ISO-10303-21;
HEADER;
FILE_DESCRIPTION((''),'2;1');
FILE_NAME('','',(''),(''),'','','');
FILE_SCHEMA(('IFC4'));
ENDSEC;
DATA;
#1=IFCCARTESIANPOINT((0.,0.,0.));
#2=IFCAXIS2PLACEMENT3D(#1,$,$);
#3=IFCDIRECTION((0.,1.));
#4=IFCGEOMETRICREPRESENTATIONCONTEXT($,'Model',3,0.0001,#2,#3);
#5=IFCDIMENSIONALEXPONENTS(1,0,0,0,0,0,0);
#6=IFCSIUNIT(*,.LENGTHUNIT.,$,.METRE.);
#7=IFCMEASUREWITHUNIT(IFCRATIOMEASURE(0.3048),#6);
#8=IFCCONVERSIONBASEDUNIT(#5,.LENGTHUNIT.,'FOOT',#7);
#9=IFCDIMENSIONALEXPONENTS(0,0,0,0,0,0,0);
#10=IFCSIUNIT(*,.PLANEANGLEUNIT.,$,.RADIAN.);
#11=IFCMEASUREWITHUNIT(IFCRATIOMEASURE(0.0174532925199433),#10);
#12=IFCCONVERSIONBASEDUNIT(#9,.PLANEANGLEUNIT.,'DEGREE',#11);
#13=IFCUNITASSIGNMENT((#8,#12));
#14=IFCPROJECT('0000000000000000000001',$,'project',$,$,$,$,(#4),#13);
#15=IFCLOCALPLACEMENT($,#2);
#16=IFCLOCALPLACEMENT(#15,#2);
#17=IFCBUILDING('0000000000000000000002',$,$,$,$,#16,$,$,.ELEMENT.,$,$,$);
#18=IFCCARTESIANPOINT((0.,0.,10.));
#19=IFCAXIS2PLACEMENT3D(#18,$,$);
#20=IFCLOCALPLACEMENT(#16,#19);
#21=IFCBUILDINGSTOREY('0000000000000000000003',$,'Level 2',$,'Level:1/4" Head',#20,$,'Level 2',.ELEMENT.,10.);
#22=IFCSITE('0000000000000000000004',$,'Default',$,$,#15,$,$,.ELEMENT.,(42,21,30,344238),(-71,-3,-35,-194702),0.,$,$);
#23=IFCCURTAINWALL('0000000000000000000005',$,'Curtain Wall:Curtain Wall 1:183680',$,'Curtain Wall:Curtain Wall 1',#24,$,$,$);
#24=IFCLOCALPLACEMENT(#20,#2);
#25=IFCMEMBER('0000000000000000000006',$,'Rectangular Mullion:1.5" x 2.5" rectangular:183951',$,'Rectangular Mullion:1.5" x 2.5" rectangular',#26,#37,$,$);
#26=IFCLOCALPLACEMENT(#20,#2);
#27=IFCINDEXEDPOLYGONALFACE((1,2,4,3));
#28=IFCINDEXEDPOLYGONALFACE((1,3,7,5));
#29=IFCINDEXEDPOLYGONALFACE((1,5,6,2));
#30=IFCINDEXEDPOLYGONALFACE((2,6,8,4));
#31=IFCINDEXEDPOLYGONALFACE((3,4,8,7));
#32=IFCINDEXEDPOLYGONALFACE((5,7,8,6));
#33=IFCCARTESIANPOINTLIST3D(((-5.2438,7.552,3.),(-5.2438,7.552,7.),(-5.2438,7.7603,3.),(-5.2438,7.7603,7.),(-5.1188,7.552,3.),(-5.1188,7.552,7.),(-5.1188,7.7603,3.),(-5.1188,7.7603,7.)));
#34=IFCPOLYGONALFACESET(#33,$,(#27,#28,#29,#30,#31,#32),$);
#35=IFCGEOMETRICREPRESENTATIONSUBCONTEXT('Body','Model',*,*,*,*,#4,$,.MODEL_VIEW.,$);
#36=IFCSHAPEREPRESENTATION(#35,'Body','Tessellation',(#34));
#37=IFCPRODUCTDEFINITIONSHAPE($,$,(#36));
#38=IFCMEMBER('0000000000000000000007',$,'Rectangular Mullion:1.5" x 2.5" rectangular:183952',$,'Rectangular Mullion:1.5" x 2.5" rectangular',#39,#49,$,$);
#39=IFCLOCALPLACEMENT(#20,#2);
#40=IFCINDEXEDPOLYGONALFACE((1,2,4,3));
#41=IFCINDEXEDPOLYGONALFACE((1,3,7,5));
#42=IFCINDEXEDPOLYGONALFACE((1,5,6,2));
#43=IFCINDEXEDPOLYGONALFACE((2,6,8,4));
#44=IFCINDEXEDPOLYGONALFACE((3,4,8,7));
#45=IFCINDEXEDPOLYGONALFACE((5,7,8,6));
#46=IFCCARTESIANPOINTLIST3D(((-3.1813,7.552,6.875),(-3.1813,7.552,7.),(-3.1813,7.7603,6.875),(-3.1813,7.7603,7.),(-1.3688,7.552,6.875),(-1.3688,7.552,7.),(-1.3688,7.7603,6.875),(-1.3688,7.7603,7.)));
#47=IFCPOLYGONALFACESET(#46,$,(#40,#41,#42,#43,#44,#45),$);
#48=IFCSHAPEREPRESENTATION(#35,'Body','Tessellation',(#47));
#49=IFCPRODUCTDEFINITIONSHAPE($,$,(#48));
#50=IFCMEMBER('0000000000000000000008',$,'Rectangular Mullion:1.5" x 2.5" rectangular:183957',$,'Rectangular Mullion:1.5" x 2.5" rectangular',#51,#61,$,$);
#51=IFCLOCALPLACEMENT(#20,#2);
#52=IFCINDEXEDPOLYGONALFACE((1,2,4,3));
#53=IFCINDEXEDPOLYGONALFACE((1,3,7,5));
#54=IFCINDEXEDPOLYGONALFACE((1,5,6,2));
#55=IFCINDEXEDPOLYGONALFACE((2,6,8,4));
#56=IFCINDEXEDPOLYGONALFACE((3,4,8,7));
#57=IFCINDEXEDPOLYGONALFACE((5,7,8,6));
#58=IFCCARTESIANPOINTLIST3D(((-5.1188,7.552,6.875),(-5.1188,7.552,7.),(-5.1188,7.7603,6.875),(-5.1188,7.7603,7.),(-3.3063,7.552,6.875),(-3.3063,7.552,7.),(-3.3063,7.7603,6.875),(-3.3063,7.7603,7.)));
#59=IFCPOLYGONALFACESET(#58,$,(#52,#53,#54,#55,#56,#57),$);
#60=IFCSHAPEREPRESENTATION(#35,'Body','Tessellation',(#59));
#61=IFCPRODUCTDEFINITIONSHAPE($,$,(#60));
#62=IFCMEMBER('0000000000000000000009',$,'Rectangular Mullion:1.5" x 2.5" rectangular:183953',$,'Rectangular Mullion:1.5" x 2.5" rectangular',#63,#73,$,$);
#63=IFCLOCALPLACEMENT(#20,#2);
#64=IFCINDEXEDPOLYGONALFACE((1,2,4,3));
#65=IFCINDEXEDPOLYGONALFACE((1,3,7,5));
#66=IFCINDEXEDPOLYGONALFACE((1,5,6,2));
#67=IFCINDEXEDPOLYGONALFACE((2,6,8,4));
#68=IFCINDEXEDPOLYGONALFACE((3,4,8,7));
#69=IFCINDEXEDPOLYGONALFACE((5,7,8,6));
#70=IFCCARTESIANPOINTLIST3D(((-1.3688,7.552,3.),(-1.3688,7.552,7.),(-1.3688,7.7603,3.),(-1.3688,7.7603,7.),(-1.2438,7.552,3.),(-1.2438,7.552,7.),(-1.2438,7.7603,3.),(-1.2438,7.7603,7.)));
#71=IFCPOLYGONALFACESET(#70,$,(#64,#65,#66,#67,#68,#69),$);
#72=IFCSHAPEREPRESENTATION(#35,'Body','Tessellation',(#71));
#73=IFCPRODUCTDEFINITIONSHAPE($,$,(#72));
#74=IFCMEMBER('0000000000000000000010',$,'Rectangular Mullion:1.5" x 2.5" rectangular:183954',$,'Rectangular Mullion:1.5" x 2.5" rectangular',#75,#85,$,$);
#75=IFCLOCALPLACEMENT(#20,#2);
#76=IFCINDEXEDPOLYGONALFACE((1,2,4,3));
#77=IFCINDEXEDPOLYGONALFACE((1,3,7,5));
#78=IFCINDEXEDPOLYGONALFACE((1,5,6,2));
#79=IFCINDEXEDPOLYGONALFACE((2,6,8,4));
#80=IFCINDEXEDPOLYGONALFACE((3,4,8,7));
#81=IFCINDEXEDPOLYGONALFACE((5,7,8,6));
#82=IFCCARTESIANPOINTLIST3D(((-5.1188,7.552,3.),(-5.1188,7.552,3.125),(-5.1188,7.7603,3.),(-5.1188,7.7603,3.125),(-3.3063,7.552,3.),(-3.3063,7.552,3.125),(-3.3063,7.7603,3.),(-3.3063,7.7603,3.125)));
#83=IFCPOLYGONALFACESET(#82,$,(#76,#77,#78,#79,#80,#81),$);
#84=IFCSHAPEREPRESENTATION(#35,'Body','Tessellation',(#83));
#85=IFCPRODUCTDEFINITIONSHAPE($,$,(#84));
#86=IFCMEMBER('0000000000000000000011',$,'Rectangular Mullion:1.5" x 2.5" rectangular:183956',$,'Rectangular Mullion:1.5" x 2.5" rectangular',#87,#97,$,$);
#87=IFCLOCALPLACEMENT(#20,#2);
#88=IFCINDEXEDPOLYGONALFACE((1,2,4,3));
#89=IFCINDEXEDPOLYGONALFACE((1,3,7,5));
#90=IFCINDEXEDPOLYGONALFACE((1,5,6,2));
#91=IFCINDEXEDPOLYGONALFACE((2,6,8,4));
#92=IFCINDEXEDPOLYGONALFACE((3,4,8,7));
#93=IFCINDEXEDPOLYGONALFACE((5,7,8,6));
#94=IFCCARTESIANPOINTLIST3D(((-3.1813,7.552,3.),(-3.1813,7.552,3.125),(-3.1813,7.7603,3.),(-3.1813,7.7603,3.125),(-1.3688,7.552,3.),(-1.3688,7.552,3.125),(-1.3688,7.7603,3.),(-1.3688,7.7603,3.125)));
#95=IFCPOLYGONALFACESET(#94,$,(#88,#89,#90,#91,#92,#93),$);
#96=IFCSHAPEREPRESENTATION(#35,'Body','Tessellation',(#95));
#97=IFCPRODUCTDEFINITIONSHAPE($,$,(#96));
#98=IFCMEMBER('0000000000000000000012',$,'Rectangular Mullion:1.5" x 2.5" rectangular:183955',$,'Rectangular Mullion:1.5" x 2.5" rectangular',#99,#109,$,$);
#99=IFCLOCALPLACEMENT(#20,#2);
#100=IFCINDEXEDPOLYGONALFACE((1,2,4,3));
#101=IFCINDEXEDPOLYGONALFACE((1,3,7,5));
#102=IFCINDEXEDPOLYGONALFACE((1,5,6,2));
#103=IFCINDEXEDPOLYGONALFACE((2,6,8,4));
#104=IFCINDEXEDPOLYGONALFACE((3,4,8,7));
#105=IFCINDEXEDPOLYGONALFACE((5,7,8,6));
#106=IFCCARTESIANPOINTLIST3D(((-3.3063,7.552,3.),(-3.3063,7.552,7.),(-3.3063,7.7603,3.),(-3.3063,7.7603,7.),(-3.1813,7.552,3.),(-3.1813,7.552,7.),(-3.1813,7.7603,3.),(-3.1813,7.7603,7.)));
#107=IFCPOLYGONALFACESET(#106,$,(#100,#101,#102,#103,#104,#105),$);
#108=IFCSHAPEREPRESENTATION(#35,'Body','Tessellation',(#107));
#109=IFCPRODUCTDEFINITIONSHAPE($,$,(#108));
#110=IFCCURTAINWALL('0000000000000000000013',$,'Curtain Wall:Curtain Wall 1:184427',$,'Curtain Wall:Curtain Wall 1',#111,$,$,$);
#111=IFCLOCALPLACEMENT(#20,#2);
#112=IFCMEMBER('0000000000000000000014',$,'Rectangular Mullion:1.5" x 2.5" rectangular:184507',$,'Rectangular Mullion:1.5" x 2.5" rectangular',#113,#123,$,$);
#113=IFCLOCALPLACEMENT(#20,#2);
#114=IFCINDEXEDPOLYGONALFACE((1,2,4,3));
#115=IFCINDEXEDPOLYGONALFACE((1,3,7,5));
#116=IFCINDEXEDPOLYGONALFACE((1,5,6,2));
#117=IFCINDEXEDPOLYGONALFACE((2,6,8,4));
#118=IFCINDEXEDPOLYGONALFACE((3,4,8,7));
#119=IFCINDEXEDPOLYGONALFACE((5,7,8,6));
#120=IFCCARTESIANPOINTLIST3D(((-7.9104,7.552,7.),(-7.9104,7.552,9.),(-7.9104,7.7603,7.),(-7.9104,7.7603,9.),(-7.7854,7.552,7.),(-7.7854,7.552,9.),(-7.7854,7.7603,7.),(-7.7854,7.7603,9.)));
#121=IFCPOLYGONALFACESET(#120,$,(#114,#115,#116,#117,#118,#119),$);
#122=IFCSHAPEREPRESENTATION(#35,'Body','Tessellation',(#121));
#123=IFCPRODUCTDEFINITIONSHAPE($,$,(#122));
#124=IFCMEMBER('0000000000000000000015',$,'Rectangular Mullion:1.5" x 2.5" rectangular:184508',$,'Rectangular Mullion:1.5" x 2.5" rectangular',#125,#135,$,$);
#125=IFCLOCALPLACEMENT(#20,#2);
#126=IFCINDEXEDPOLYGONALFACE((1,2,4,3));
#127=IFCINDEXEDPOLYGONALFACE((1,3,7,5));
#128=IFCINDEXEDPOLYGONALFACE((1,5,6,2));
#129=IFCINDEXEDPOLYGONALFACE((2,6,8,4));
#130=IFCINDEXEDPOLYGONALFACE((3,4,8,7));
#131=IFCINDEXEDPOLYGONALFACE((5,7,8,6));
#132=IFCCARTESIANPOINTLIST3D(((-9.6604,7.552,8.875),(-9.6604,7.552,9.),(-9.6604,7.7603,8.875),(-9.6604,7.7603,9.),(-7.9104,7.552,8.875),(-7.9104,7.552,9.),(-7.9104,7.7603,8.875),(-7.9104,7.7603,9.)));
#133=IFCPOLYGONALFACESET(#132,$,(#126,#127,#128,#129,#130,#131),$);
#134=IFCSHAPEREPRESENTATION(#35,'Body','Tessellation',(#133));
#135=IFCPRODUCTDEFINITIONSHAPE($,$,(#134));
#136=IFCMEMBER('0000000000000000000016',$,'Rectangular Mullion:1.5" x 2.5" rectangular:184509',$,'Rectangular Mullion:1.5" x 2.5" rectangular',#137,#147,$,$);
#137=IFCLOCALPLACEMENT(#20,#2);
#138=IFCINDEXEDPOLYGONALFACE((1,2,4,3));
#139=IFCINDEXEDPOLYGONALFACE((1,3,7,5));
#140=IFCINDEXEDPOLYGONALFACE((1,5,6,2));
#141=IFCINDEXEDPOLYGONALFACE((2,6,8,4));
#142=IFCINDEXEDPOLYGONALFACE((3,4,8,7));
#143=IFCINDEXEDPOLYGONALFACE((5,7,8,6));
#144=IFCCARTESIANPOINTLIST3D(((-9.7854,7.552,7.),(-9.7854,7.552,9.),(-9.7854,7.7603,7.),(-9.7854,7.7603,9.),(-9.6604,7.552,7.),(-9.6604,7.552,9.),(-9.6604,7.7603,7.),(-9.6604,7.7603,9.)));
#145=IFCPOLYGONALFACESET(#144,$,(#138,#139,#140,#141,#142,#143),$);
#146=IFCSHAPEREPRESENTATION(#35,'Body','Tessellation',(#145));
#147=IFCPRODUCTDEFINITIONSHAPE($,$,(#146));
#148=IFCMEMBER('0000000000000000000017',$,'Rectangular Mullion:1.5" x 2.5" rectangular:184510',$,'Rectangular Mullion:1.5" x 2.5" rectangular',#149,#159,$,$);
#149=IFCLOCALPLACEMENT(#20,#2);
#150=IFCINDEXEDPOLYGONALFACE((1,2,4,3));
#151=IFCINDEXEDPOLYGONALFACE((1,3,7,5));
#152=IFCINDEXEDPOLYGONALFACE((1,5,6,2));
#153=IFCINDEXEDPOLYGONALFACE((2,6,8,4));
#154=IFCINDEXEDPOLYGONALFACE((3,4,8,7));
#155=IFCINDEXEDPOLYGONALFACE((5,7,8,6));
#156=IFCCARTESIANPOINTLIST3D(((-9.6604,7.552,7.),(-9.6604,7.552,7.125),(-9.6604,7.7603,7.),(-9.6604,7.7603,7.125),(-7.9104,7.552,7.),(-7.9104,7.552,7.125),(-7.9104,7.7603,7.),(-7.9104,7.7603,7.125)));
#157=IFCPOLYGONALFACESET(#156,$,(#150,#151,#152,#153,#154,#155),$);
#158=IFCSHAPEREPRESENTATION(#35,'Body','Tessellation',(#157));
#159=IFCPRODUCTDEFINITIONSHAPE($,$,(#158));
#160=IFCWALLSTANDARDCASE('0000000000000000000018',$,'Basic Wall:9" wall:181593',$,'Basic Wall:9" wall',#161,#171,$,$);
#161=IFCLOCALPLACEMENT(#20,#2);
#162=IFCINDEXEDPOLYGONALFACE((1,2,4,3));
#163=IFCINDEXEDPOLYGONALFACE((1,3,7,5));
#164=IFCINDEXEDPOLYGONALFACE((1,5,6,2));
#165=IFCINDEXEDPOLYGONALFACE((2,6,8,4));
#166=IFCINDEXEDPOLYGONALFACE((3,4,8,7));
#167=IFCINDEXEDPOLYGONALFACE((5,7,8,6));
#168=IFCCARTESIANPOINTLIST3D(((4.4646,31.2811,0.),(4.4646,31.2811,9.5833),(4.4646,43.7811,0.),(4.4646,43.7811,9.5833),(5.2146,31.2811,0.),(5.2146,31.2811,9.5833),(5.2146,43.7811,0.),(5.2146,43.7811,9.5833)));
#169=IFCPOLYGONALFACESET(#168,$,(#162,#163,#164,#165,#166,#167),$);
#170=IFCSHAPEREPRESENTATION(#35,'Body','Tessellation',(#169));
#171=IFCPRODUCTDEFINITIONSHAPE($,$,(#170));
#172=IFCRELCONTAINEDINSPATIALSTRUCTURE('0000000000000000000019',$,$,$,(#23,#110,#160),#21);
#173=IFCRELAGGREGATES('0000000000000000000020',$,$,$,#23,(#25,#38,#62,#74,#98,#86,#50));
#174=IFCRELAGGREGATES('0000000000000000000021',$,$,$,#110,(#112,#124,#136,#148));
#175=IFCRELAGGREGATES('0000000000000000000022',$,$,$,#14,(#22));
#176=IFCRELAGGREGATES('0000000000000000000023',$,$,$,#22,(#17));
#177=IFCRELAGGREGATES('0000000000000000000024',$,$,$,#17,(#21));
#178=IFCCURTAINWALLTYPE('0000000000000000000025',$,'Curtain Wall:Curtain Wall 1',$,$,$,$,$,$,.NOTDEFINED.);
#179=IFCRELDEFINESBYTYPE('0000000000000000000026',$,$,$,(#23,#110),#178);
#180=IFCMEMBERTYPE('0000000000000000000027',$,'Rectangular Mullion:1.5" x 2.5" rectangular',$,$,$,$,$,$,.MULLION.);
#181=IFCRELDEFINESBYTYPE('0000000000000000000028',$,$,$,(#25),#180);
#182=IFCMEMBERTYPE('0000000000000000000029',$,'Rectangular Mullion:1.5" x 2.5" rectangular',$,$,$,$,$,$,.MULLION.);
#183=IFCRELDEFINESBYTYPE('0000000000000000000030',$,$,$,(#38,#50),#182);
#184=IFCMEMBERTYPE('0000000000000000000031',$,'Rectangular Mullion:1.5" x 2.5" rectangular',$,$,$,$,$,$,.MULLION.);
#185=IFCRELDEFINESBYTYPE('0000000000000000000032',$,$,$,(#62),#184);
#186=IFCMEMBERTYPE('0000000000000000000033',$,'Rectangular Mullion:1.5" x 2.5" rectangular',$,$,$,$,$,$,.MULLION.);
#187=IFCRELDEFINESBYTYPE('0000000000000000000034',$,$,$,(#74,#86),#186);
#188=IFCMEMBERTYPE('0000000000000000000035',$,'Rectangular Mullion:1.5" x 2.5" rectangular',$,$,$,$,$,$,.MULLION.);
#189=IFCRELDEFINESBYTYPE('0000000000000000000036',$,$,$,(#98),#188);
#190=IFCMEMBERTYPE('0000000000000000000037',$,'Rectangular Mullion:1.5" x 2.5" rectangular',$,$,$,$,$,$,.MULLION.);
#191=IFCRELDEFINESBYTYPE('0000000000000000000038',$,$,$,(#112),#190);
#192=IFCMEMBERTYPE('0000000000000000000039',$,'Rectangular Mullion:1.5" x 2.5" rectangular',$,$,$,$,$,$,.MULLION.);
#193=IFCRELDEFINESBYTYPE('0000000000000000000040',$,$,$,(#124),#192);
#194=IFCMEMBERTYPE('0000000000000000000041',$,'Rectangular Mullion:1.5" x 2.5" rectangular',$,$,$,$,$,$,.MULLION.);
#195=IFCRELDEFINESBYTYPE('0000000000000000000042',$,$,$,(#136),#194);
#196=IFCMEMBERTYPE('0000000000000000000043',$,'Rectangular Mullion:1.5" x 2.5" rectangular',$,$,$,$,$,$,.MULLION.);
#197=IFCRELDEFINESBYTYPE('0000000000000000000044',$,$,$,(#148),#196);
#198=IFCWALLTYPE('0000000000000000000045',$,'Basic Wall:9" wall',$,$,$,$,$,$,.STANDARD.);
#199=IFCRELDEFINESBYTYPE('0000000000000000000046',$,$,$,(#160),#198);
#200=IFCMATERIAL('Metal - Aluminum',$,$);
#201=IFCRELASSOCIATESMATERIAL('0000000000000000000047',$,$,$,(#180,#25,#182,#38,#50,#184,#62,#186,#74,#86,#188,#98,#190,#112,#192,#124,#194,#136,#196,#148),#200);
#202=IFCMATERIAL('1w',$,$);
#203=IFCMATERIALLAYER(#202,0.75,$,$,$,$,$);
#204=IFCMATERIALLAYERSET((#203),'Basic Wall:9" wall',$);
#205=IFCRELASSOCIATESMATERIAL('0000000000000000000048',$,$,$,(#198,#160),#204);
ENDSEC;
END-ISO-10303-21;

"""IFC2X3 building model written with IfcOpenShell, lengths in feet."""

from ifc_helpers import new_model, entity, si_unit, converted_unit, direction, frame, frame_2d, origin, origin_2d_with_axis, place, context, subcontext, project, spatial, polyline, rectangle, extrude, clip, bounded_halfspace, source, transform, mapped, material, layer, layer_set, layer_usage, type_object, type_shapes, element, aggregate, save


model = new_model("IFC2X3")

# Units and contexts
model_context = context("Model", 3, precision=0.0001, world=origin(), true_north=direction((0.0, 1.0)))
body_context = subcontext(model_context, "Body", "Model", "MODEL_VIEW")
ifc_project = project(units=[converted_unit("LENGTHUNIT", "FOOT", entity("IfcRatioMeasure", 0.3048), si_unit("LENGTHUNIT", "METRE"), dimensions=[1, 0, 0, 0, 0, 0, 0]), converted_unit("PLANEANGLEUNIT", "DEGREE", entity("IfcRatioMeasure", 0.0174532925199433), si_unit("PLANEANGLEUNIT", "RADIAN"), dimensions=[0, 0, 0, 0, 0, 0, 0])], contexts=[model_context])

# Site, building, storey
site_placement = place(None, origin())
site = spatial("IfcSite", under=ifc_project, at=site_placement, Name="Default", CompositionType="ELEMENT", RefLatitude=(42, 21, 30, 344238), RefLongitude=(-71, -3, -35, -194702), RefElevation=0.0)
building_placement = place(site_placement, origin())
building = spatial("IfcBuilding", under=site, at=building_placement, CompositionType="ELEMENT")
storey_placement = place(building_placement, frame((0.0, 0.0, 10.0)))
storey = spatial("IfcBuildingStorey", under=building, at=storey_placement, Name="Level 2", ObjectType="Level:1/4\" Head", LongName="Level 2", CompositionType="ELEMENT", Elevation=10.0)

# Curtain walls, members
curtain_wall_type = type_object("IfcCurtainWallType", Name="Curtain Wall:Curtain Wall 1", PredefinedType="NOTDEFINED")
curtain_wall_1_placement = place(storey_placement, frame((0.0, 0.0, -10.0)))
curtain_wall_1 = element("IfcCurtainWall", 1, at=curtain_wall_1_placement, inside=storey, type_object=curtain_wall_type, Name="Curtain Wall:Curtain Wall 1:183680", ObjectType="Curtain Wall:Curtain Wall 1")
ifc_material_1 = material(Name="Metal - Aluminum")
member_type_1 = type_object("IfcMemberType", Name="Rectangular Mullion:1.5\" x 2.5\" rectangular", PredefinedType="MULLION", material=ifc_material_1)
shared_shape_1 = source(origin(), body_context, "Body", "SweptSolid", [
    extrude(rectangle(XDim=0.2083, YDim=0.125, at=origin_2d_with_axis()), frame((-0.0625, 0.0, -4.0), z_axis=(0.0, 0.0, 1.0), x_axis=(0.0, -1.0, 0.0)), (0.0, 0.0, 1.0), 4.0),
])
type_shapes(member_type_1, [shared_shape_1])
member_1_placement = place(storey_placement, frame((-5.2438, 7.6561, 7.0), z_axis=(0.0, 0.0, 1.0), x_axis=(-1.0, 0.0, 0.0)))
member_1 = element("IfcMember", 2, at=member_1_placement, type_object=member_type_1, material=ifc_material_1, Name="Rectangular Mullion:1.5\" x 2.5\" rectangular:183951", ObjectType="Rectangular Mullion:1.5\" x 2.5\" rectangular", context=body_context, shape_type="MappedRepresentation", body=[
    mapped(shared_shape_1, transform((0.0, 0.0, 0.0), scale=1.0)),
])
member_type_2 = type_object("IfcMemberType", Name="Rectangular Mullion:1.5\" x 2.5\" rectangular", PredefinedType="MULLION", material=ifc_material_1)
shared_shape_2 = source(origin(), body_context, "Body", "SweptSolid", [
    extrude(rectangle(XDim=0.2083, YDim=0.125, at=origin_2d_with_axis()), frame((-0.0625, 0.0, -1.8125), z_axis=(0.0, 0.0, 1.0), x_axis=(0.0, -1.0, 0.0)), (0.0, 0.0, 1.0), 1.8125),
])
type_shapes(member_type_2, [shared_shape_2])
member_2_placement = place(storey_placement, frame((-1.3688, 7.6561, 7.0), z_axis=(1.0, 0.0, 0.0), x_axis=(0.0, 0.0, 1.0)))
member_2 = element("IfcMember", 3, at=member_2_placement, type_object=member_type_2, material=ifc_material_1, Name="Rectangular Mullion:1.5\" x 2.5\" rectangular:183952", ObjectType="Rectangular Mullion:1.5\" x 2.5\" rectangular", context=body_context, shape_type="MappedRepresentation", body=[
    mapped(shared_shape_2, transform((0.0, 0.0, 0.0), scale=1.0)),
])
member_3_placement = place(storey_placement, frame((-3.3063, 7.6561, 7.0), z_axis=(1.0, 0.0, 0.0), x_axis=(0.0, 0.0, 1.0)))
member_3 = element("IfcMember", 4, at=member_3_placement, type_object=member_type_2, material=ifc_material_1, Name="Rectangular Mullion:1.5\" x 2.5\" rectangular:183957", ObjectType="Rectangular Mullion:1.5\" x 2.5\" rectangular", context=body_context, shape_type="MappedRepresentation", body=[
    mapped(shared_shape_2, transform((0.0, 0.0, 0.0), scale=1.0)),
])
member_type_3 = type_object("IfcMemberType", Name="Rectangular Mullion:1.5\" x 2.5\" rectangular", PredefinedType="MULLION", material=ifc_material_1)
shared_shape_3 = source(origin(), body_context, "Body", "SweptSolid", [
    extrude(rectangle(XDim=0.2083, YDim=0.125, at=origin_2d_with_axis()), frame((-0.0625, 0.0, -4.0), z_axis=(0.0, 0.0, 1.0), x_axis=(0.0, -1.0, 0.0)), (0.0, 0.0, 1.0), 4.0),
])
type_shapes(member_type_3, [shared_shape_3])
member_4_placement = place(storey_placement, frame((-1.2438, 7.6561, 3.0), z_axis=(0.0, 0.0, -1.0), x_axis=(1.0, 0.0, 0.0)))
member_4 = element("IfcMember", 5, at=member_4_placement, type_object=member_type_3, material=ifc_material_1, Name="Rectangular Mullion:1.5\" x 2.5\" rectangular:183953", ObjectType="Rectangular Mullion:1.5\" x 2.5\" rectangular", context=body_context, shape_type="MappedRepresentation", body=[
    mapped(shared_shape_3, transform((0.0, 0.0, 0.0), scale=1.0)),
])
member_type_4 = type_object("IfcMemberType", Name="Rectangular Mullion:1.5\" x 2.5\" rectangular", PredefinedType="MULLION", material=ifc_material_1)
shared_shape_4 = source(origin(), body_context, "Body", "SweptSolid", [
    extrude(rectangle(XDim=0.2083, YDim=0.125, at=origin_2d_with_axis()), frame((-0.0625, 0.0, -1.8125), z_axis=(0.0, 0.0, 1.0), x_axis=(0.0, -1.0, 0.0)), (0.0, 0.0, 1.0), 1.8125),
])
type_shapes(member_type_4, [shared_shape_4])
member_5_placement = place(storey_placement, frame((-5.1188, 7.6561, 3.0), z_axis=(-1.0, 0.0, 0.0), x_axis=(0.0, 0.0, -1.0)))
member_5 = element("IfcMember", 6, at=member_5_placement, type_object=member_type_4, material=ifc_material_1, Name="Rectangular Mullion:1.5\" x 2.5\" rectangular:183954", ObjectType="Rectangular Mullion:1.5\" x 2.5\" rectangular", context=body_context, shape_type="MappedRepresentation", body=[
    mapped(shared_shape_4, transform((0.0, 0.0, 0.0), scale=1.0)),
])
member_6_placement = place(storey_placement, frame((-3.1813, 7.6561, 3.0), z_axis=(-1.0, 0.0, 0.0), x_axis=(0.0, 0.0, -1.0)))
member_6 = element("IfcMember", 7, at=member_6_placement, type_object=member_type_4, material=ifc_material_1, Name="Rectangular Mullion:1.5\" x 2.5\" rectangular:183956", ObjectType="Rectangular Mullion:1.5\" x 2.5\" rectangular", context=body_context, shape_type="MappedRepresentation", body=[
    mapped(shared_shape_4, transform((0.0, 0.0, 0.0), scale=1.0)),
])
member_type_5 = type_object("IfcMemberType", Name="Rectangular Mullion:1.5\" x 2.5\" rectangular", PredefinedType="MULLION", material=ifc_material_1)
shared_shape_5 = source(origin(), body_context, "Body", "SweptSolid", [
    extrude(rectangle(XDim=0.2083, YDim=0.125, at=origin_2d_with_axis()), frame((0.0, 0.0, -4.0), z_axis=(0.0, 0.0, 1.0), x_axis=(0.0, -1.0, 0.0)), (0.0, 0.0, 1.0), 4.0),
])
type_shapes(member_type_5, [shared_shape_5])
member_7_placement = place(storey_placement, frame((-3.2438, 7.6561, 3.0), z_axis=(0.0, 0.0, -1.0), x_axis=(1.0, 0.0, 0.0)))
member_7 = element("IfcMember", 8, at=member_7_placement, type_object=member_type_5, material=ifc_material_1, Name="Rectangular Mullion:1.5\" x 2.5\" rectangular:183955", ObjectType="Rectangular Mullion:1.5\" x 2.5\" rectangular", context=body_context, shape_type="MappedRepresentation", body=[
    mapped(shared_shape_5, transform((0.0, 0.0, 0.0), scale=1.0)),
])
curtain_wall_2_placement = place(storey_placement, frame((0.0, 0.0, -10.0)))
curtain_wall_2 = element("IfcCurtainWall", 9, at=curtain_wall_2_placement, inside=storey, type_object=curtain_wall_type, Name="Curtain Wall:Curtain Wall 1:184427", ObjectType="Curtain Wall:Curtain Wall 1")
member_type_6 = type_object("IfcMemberType", Name="Rectangular Mullion:1.5\" x 2.5\" rectangular", PredefinedType="MULLION", material=ifc_material_1)
shared_shape_6 = source(origin(), body_context, "Body", "SweptSolid", [
    extrude(rectangle(XDim=0.2083, YDim=0.125, at=origin_2d_with_axis()), frame((-0.0625, 0.0, -2.0), z_axis=(0.0, 0.0, 1.0), x_axis=(0.0, -1.0, 0.0)), (0.0, 0.0, 1.0), 2.0),
])
type_shapes(member_type_6, [shared_shape_6])
member_8_placement = place(storey_placement, frame((-7.7854, 7.6561, 9.0)))
member_8 = element("IfcMember", 10, at=member_8_placement, type_object=member_type_6, material=ifc_material_1, Name="Rectangular Mullion:1.5\" x 2.5\" rectangular:184507", ObjectType="Rectangular Mullion:1.5\" x 2.5\" rectangular", context=body_context, shape_type="MappedRepresentation", body=[
    mapped(shared_shape_6, transform((0.0, 0.0, 0.0), scale=1.0)),
])
member_type_7 = type_object("IfcMemberType", Name="Rectangular Mullion:1.5\" x 2.5\" rectangular", PredefinedType="MULLION", material=ifc_material_1)
shared_shape_7 = source(origin(), body_context, "Body", "SweptSolid", [
    extrude(rectangle(XDim=0.2083, YDim=0.125, at=origin_2d_with_axis()), frame((-0.0625, 0.0, -1.75), z_axis=(0.0, 0.0, 1.0), x_axis=(0.0, -1.0, 0.0)), (0.0, 0.0, 1.0), 1.75),
])
type_shapes(member_type_7, [shared_shape_7])
member_9_placement = place(storey_placement, frame((-9.6604, 7.6561, 9.0), z_axis=(-1.0, 0.0, 0.0), x_axis=(0.0, 0.0, 1.0)))
member_9 = element("IfcMember", 11, at=member_9_placement, type_object=member_type_7, material=ifc_material_1, Name="Rectangular Mullion:1.5\" x 2.5\" rectangular:184508", ObjectType="Rectangular Mullion:1.5\" x 2.5\" rectangular", context=body_context, shape_type="MappedRepresentation", body=[
    mapped(shared_shape_7, transform((0.0, 0.0, 0.0), scale=1.0)),
])
member_type_8 = type_object("IfcMemberType", Name="Rectangular Mullion:1.5\" x 2.5\" rectangular", PredefinedType="MULLION", material=ifc_material_1)
shared_shape_8 = source(origin(), body_context, "Body", "SweptSolid", [
    extrude(rectangle(XDim=0.2083, YDim=0.125, at=origin_2d_with_axis()), frame((-0.0625, 0.0, -2.0), z_axis=(0.0, 0.0, 1.0), x_axis=(0.0, -1.0, 0.0)), (0.0, 0.0, 1.0), 2.0),
])
type_shapes(member_type_8, [shared_shape_8])
member_10_placement = place(storey_placement, frame((-9.7854, 7.6561, 7.0), z_axis=(0.0, 0.0, -1.0), x_axis=(-1.0, 0.0, 0.0)))
member_10 = element("IfcMember", 12, at=member_10_placement, type_object=member_type_8, material=ifc_material_1, Name="Rectangular Mullion:1.5\" x 2.5\" rectangular:184509", ObjectType="Rectangular Mullion:1.5\" x 2.5\" rectangular", context=body_context, shape_type="MappedRepresentation", body=[
    mapped(shared_shape_8, transform((0.0, 0.0, 0.0), scale=1.0)),
])
member_type_9 = type_object("IfcMemberType", Name="Rectangular Mullion:1.5\" x 2.5\" rectangular", PredefinedType="MULLION", material=ifc_material_1)
shared_shape_9 = source(origin(), body_context, "Body", "SweptSolid", [
    extrude(rectangle(XDim=0.2083, YDim=0.125, at=origin_2d_with_axis()), frame((-0.0625, 0.0, -1.75), z_axis=(0.0, 0.0, 1.0), x_axis=(0.0, -1.0, 0.0)), (0.0, 0.0, 1.0), 1.75),
])
type_shapes(member_type_9, [shared_shape_9])
member_11_placement = place(storey_placement, frame((-7.9104, 7.6561, 7.0), z_axis=(1.0, 0.0, 0.0), x_axis=(0.0, 0.0, -1.0)))
member_11 = element("IfcMember", 13, at=member_11_placement, type_object=member_type_9, material=ifc_material_1, Name="Rectangular Mullion:1.5\" x 2.5\" rectangular:184510", ObjectType="Rectangular Mullion:1.5\" x 2.5\" rectangular", context=body_context, shape_type="MappedRepresentation", body=[
    mapped(shared_shape_9, transform((0.0, 0.0, 0.0), scale=1.0)),
])

# Shared definitions
ifc_material_2 = material(Name="1w")

aggregate(curtain_wall_1, [member_1, member_2, member_4, member_5, member_7, member_6, member_3])
aggregate(curtain_wall_2, [member_8, member_9, member_10, member_11])

# Wall
ifc_layer_1 = layer(ifc_material_2, 0.75)
ifc_layer_set_1 = layer_set([ifc_layer_1], Name="Basic Wall:9\" wall")
ifc_layer_usage_1 = layer_usage(ifc_layer_set_1, "AXIS2", "NEGATIVE", 0.375)
wall_type = type_object("IfcWallType", Name="Basic Wall:9\" wall", PredefinedType="STANDARD", material=ifc_layer_set_1)
wall_1_placement = place(storey_placement, frame((4.8396, 31.2811, 0.0), z_axis=(0.0, 0.0, 1.0), x_axis=(0.0, 1.0, 0.0)))
element("IfcWallStandardCase", 14, at=wall_1_placement, inside=storey, type_object=wall_type, material=ifc_layer_usage_1, Name="Basic Wall:9\" wall:181593", ObjectType="Basic Wall:9\" wall", context=body_context, shape_type="Clipping", body=[
    clip(extrude(rectangle(XDim=12.5, YDim=0.75, at=frame_2d((6.25, 0.0), x_axis=(-1.0, 0.0))), origin(), (0.0, 0.0, 1.0), 9.5833), bounded_halfspace(frame((0.0, -0.375, 9.5833), z_axis=(0.0, 0.0, -1.0), x_axis=(-1.0, 0.0, 0.0)), True, frame((0.0, -0.375, 9.5833)), polyline([(0.0, 0.0), (12.5, 0.0), (12.5, 0.75), (11.75, 0.75), (0.75, 0.75), (0.0, 0.75), (0.0, 0.0)]))),
])

save(model, "model.ifc")
